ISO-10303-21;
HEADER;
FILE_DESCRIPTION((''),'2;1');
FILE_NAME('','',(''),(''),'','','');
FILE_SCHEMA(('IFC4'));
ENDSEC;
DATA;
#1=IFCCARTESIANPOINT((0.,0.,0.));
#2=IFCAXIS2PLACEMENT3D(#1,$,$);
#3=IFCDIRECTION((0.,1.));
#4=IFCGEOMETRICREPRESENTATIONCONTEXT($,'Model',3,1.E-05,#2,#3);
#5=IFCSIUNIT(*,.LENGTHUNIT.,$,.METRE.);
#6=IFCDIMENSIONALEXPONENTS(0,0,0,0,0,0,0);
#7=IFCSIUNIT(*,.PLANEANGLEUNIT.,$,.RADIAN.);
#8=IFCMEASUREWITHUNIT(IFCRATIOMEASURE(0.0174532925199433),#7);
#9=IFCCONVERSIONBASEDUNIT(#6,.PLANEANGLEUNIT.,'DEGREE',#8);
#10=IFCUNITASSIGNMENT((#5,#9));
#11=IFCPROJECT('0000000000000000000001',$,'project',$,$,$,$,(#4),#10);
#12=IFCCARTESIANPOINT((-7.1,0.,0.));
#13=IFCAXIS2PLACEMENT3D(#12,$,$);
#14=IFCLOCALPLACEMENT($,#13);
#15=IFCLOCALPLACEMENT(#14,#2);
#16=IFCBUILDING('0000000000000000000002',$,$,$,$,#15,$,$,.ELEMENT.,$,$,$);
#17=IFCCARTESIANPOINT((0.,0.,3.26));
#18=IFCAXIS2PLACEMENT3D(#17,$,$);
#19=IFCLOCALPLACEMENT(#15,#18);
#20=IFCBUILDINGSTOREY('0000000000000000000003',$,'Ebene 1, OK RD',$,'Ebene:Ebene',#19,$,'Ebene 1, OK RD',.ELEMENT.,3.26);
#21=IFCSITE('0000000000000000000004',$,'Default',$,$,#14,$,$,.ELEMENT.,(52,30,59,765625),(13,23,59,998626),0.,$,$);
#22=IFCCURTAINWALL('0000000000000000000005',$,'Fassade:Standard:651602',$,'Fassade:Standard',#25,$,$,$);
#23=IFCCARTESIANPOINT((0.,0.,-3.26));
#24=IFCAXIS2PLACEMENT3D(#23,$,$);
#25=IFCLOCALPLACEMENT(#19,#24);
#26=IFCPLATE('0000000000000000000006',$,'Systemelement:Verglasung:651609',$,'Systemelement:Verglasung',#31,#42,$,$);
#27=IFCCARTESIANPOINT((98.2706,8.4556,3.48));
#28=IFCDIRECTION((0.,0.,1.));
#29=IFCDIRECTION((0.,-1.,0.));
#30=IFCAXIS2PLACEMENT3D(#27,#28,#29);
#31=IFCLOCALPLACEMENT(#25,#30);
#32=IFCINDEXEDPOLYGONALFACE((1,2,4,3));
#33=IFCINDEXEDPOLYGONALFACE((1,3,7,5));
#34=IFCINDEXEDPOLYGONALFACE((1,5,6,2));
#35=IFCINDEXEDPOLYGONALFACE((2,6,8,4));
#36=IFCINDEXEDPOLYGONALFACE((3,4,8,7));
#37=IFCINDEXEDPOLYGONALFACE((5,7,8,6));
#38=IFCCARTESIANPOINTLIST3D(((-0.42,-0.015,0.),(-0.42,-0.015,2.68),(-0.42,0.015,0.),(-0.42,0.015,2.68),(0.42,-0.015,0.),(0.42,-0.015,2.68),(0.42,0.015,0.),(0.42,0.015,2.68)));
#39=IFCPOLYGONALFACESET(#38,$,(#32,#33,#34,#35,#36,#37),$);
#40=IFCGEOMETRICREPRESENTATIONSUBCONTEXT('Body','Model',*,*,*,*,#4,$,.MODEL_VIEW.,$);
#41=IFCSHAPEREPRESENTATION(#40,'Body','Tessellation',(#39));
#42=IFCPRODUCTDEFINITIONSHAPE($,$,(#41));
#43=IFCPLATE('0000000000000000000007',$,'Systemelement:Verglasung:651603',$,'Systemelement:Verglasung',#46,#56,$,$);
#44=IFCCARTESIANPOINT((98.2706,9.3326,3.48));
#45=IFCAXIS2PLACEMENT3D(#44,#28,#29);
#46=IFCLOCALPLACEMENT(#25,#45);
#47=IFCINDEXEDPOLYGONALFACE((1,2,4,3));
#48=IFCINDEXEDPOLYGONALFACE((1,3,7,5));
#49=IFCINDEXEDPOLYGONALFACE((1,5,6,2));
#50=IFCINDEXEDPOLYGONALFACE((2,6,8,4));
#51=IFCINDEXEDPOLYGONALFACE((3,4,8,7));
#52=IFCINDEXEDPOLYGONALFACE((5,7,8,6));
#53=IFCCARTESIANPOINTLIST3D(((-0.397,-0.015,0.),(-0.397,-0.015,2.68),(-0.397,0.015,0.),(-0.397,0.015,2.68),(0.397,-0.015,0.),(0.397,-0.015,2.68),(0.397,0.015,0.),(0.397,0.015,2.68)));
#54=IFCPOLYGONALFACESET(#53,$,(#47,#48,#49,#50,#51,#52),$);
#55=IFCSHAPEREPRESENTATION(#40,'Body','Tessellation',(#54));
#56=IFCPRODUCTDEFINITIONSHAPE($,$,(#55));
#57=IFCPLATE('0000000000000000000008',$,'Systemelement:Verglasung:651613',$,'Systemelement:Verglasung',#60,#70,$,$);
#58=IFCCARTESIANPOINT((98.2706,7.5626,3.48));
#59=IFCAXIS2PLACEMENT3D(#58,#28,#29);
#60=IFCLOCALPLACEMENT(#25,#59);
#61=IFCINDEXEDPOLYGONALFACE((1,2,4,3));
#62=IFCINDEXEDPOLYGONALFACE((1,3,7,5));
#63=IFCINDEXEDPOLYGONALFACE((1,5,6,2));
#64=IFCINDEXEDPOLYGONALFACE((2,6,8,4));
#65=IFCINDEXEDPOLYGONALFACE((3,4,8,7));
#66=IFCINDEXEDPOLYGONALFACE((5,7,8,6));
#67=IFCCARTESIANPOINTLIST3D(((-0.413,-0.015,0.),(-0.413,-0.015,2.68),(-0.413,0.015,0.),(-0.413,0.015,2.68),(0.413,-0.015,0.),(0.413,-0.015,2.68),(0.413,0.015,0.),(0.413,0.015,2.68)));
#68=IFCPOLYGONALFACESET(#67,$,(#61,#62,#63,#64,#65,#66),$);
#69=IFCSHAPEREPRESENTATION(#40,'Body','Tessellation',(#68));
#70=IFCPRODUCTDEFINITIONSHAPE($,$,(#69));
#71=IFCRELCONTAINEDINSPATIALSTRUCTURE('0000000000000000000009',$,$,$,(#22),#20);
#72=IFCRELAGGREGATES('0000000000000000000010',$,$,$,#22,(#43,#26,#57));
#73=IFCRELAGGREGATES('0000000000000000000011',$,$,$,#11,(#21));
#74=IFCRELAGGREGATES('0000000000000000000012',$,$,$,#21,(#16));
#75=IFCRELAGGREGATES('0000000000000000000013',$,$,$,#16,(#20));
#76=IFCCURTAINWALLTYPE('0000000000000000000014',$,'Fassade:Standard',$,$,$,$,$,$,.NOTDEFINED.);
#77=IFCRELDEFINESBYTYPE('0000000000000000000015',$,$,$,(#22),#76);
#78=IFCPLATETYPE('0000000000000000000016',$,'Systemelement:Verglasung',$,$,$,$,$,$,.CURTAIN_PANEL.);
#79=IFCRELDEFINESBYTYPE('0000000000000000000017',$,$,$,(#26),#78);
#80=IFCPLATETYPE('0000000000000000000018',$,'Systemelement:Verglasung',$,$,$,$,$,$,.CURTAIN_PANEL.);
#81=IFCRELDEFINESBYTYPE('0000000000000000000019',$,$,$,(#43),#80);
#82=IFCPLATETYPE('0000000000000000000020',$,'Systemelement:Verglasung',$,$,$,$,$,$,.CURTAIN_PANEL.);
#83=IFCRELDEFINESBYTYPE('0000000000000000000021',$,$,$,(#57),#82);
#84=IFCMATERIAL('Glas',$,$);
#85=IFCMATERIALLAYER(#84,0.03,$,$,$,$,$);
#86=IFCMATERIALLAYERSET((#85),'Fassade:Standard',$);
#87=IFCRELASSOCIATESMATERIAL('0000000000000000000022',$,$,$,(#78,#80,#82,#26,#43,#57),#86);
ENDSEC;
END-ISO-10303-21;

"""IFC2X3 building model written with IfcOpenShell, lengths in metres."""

from ifc_helpers import new_model, entity, si_unit, converted_unit, direction, frame, origin, origin_2d_with_axis, place, context, subcontext, project, spatial, rectangle, extrude, source, transform, mapped, material, layer, layer_set, layer_usage, type_object, type_shapes, element, aggregate, save


model = new_model("IFC2X3")

# Units and contexts
model_context = context("Model", 3, precision=1e-05, world=origin(), true_north=direction((0.0, 1.0)))
body_context = subcontext(model_context, "Body", "Model", "MODEL_VIEW")
ifc_project = project(units=[si_unit("LENGTHUNIT", "METRE"), converted_unit("PLANEANGLEUNIT", "DEGREE", entity("IfcRatioMeasure", 0.0174532925199433), si_unit("PLANEANGLEUNIT", "RADIAN"), dimensions=[0, 0, 0, 0, 0, 0, 0])], contexts=[model_context])

# Site, building, storey
site_placement = place(None, frame((-7.1, 0.0, 0.0)))
site = spatial("IfcSite", under=ifc_project, at=site_placement, Name="Default", CompositionType="ELEMENT", RefLatitude=(52, 30, 59, 765625), RefLongitude=(13, 23, 59, 998626), RefElevation=0.0)
building_placement = place(site_placement, origin())
building = spatial("IfcBuilding", under=site, at=building_placement, CompositionType="ELEMENT")
storey_placement = place(building_placement, frame((0.0, 0.0, 3.26)))
storey = spatial("IfcBuildingStorey", under=building, at=storey_placement, Name="Ebene 1, OK RD", ObjectType="Ebene:Ebene", LongName="Ebene 1, OK RD", CompositionType="ELEMENT", Elevation=3.26)

# Curtain wall
curtain_wall_type = type_object("IfcCurtainWallType", Name="Fassade:Standard", PredefinedType="NOTDEFINED")
curtain_wall_placement = place(storey_placement, frame((0.0, 0.0, -3.26)))
curtain_wall = element("IfcCurtainWall", 1, at=curtain_wall_placement, inside=storey, type_object=curtain_wall_type, Name="Fassade:Standard:651602", ObjectType="Fassade:Standard")

# Plates
ifc_material_1 = material(Name="Glas")
ifc_layer_1 = layer(ifc_material_1, 0.03)
ifc_layer_set_1 = layer_set([ifc_layer_1], Name="Fassade:Standard")
ifc_layer_usage_1 = layer_usage(ifc_layer_set_1, "AXIS3", "POSITIVE", 0.0)
plate_type_1 = type_object("IfcPlateType", Name="Systemelement:Verglasung", PredefinedType="CURTAIN_PANEL", material=ifc_layer_set_1)
shared_shape_1 = source(origin(), body_context, "Body", "SweptSolid", [
    extrude(rectangle(XDim=0.03, YDim=0.84, at=origin_2d_with_axis()), frame((0.0, 0.0, 0.0), z_axis=(0.0, 0.0, 1.0), x_axis=(0.0, 1.0, 0.0)), (0.0, 0.0, 1.0), 2.68),
])
type_shapes(plate_type_1, [shared_shape_1])
plate_1_placement = place(curtain_wall_placement, frame((98.2706, 8.4556, 3.48), z_axis=(0.0, 0.0, 1.0), x_axis=(0.0, -1.0, 0.0)))
plate_1 = element("IfcPlate", 2, at=plate_1_placement, type_object=plate_type_1, material=ifc_layer_usage_1, Name="Systemelement:Verglasung:651609", ObjectType="Systemelement:Verglasung", context=body_context, shape_type="MappedRepresentation", body=[
    mapped(shared_shape_1, transform((0.0, 0.0, 0.0), scale=1.0)),
])
ifc_layer_usage_2 = layer_usage(ifc_layer_set_1, "AXIS3", "POSITIVE", 0.0)
plate_type_2 = type_object("IfcPlateType", Name="Systemelement:Verglasung", PredefinedType="CURTAIN_PANEL", material=ifc_layer_set_1)
shared_shape_2 = source(origin(), body_context, "Body", "SweptSolid", [
    extrude(rectangle(XDim=0.03, YDim=0.794, at=origin_2d_with_axis()), frame((0.0, 0.0, 0.0), z_axis=(0.0, 0.0, 1.0), x_axis=(0.0, 1.0, 0.0)), (0.0, 0.0, 1.0), 2.68),
])
type_shapes(plate_type_2, [shared_shape_2])
plate_2_placement = place(curtain_wall_placement, frame((98.2706, 9.3326, 3.48), z_axis=(0.0, 0.0, 1.0), x_axis=(0.0, -1.0, 0.0)))
plate_2 = element("IfcPlate", 3, at=plate_2_placement, type_object=plate_type_2, material=ifc_layer_usage_2, Name="Systemelement:Verglasung:651603", ObjectType="Systemelement:Verglasung", context=body_context, shape_type="MappedRepresentation", body=[
    mapped(shared_shape_2, transform((0.0, 0.0, 0.0), scale=1.0)),
])
ifc_layer_usage_3 = layer_usage(ifc_layer_set_1, "AXIS3", "POSITIVE", 0.0)
plate_type_3 = type_object("IfcPlateType", Name="Systemelement:Verglasung", PredefinedType="CURTAIN_PANEL", material=ifc_layer_set_1)
shared_shape_3 = source(origin(), body_context, "Body", "SweptSolid", [
    extrude(rectangle(XDim=0.03, YDim=0.826, at=origin_2d_with_axis()), frame((0.0, 0.0, 0.0), z_axis=(0.0, 0.0, 1.0), x_axis=(0.0, 1.0, 0.0)), (0.0, 0.0, 1.0), 2.68),
])
type_shapes(plate_type_3, [shared_shape_3])
plate_3_placement = place(curtain_wall_placement, frame((98.2706, 7.5626, 3.48), z_axis=(0.0, 0.0, 1.0), x_axis=(0.0, -1.0, 0.0)))
plate_3 = element("IfcPlate", 4, at=plate_3_placement, type_object=plate_type_3, material=ifc_layer_usage_3, Name="Systemelement:Verglasung:651613", ObjectType="Systemelement:Verglasung", context=body_context, shape_type="MappedRepresentation", body=[
    mapped(shared_shape_3, transform((0.0, 0.0, 0.0), scale=1.0)),
])
aggregate(curtain_wall, [plate_2, plate_1, plate_3])

save(model, "model.ifc")
